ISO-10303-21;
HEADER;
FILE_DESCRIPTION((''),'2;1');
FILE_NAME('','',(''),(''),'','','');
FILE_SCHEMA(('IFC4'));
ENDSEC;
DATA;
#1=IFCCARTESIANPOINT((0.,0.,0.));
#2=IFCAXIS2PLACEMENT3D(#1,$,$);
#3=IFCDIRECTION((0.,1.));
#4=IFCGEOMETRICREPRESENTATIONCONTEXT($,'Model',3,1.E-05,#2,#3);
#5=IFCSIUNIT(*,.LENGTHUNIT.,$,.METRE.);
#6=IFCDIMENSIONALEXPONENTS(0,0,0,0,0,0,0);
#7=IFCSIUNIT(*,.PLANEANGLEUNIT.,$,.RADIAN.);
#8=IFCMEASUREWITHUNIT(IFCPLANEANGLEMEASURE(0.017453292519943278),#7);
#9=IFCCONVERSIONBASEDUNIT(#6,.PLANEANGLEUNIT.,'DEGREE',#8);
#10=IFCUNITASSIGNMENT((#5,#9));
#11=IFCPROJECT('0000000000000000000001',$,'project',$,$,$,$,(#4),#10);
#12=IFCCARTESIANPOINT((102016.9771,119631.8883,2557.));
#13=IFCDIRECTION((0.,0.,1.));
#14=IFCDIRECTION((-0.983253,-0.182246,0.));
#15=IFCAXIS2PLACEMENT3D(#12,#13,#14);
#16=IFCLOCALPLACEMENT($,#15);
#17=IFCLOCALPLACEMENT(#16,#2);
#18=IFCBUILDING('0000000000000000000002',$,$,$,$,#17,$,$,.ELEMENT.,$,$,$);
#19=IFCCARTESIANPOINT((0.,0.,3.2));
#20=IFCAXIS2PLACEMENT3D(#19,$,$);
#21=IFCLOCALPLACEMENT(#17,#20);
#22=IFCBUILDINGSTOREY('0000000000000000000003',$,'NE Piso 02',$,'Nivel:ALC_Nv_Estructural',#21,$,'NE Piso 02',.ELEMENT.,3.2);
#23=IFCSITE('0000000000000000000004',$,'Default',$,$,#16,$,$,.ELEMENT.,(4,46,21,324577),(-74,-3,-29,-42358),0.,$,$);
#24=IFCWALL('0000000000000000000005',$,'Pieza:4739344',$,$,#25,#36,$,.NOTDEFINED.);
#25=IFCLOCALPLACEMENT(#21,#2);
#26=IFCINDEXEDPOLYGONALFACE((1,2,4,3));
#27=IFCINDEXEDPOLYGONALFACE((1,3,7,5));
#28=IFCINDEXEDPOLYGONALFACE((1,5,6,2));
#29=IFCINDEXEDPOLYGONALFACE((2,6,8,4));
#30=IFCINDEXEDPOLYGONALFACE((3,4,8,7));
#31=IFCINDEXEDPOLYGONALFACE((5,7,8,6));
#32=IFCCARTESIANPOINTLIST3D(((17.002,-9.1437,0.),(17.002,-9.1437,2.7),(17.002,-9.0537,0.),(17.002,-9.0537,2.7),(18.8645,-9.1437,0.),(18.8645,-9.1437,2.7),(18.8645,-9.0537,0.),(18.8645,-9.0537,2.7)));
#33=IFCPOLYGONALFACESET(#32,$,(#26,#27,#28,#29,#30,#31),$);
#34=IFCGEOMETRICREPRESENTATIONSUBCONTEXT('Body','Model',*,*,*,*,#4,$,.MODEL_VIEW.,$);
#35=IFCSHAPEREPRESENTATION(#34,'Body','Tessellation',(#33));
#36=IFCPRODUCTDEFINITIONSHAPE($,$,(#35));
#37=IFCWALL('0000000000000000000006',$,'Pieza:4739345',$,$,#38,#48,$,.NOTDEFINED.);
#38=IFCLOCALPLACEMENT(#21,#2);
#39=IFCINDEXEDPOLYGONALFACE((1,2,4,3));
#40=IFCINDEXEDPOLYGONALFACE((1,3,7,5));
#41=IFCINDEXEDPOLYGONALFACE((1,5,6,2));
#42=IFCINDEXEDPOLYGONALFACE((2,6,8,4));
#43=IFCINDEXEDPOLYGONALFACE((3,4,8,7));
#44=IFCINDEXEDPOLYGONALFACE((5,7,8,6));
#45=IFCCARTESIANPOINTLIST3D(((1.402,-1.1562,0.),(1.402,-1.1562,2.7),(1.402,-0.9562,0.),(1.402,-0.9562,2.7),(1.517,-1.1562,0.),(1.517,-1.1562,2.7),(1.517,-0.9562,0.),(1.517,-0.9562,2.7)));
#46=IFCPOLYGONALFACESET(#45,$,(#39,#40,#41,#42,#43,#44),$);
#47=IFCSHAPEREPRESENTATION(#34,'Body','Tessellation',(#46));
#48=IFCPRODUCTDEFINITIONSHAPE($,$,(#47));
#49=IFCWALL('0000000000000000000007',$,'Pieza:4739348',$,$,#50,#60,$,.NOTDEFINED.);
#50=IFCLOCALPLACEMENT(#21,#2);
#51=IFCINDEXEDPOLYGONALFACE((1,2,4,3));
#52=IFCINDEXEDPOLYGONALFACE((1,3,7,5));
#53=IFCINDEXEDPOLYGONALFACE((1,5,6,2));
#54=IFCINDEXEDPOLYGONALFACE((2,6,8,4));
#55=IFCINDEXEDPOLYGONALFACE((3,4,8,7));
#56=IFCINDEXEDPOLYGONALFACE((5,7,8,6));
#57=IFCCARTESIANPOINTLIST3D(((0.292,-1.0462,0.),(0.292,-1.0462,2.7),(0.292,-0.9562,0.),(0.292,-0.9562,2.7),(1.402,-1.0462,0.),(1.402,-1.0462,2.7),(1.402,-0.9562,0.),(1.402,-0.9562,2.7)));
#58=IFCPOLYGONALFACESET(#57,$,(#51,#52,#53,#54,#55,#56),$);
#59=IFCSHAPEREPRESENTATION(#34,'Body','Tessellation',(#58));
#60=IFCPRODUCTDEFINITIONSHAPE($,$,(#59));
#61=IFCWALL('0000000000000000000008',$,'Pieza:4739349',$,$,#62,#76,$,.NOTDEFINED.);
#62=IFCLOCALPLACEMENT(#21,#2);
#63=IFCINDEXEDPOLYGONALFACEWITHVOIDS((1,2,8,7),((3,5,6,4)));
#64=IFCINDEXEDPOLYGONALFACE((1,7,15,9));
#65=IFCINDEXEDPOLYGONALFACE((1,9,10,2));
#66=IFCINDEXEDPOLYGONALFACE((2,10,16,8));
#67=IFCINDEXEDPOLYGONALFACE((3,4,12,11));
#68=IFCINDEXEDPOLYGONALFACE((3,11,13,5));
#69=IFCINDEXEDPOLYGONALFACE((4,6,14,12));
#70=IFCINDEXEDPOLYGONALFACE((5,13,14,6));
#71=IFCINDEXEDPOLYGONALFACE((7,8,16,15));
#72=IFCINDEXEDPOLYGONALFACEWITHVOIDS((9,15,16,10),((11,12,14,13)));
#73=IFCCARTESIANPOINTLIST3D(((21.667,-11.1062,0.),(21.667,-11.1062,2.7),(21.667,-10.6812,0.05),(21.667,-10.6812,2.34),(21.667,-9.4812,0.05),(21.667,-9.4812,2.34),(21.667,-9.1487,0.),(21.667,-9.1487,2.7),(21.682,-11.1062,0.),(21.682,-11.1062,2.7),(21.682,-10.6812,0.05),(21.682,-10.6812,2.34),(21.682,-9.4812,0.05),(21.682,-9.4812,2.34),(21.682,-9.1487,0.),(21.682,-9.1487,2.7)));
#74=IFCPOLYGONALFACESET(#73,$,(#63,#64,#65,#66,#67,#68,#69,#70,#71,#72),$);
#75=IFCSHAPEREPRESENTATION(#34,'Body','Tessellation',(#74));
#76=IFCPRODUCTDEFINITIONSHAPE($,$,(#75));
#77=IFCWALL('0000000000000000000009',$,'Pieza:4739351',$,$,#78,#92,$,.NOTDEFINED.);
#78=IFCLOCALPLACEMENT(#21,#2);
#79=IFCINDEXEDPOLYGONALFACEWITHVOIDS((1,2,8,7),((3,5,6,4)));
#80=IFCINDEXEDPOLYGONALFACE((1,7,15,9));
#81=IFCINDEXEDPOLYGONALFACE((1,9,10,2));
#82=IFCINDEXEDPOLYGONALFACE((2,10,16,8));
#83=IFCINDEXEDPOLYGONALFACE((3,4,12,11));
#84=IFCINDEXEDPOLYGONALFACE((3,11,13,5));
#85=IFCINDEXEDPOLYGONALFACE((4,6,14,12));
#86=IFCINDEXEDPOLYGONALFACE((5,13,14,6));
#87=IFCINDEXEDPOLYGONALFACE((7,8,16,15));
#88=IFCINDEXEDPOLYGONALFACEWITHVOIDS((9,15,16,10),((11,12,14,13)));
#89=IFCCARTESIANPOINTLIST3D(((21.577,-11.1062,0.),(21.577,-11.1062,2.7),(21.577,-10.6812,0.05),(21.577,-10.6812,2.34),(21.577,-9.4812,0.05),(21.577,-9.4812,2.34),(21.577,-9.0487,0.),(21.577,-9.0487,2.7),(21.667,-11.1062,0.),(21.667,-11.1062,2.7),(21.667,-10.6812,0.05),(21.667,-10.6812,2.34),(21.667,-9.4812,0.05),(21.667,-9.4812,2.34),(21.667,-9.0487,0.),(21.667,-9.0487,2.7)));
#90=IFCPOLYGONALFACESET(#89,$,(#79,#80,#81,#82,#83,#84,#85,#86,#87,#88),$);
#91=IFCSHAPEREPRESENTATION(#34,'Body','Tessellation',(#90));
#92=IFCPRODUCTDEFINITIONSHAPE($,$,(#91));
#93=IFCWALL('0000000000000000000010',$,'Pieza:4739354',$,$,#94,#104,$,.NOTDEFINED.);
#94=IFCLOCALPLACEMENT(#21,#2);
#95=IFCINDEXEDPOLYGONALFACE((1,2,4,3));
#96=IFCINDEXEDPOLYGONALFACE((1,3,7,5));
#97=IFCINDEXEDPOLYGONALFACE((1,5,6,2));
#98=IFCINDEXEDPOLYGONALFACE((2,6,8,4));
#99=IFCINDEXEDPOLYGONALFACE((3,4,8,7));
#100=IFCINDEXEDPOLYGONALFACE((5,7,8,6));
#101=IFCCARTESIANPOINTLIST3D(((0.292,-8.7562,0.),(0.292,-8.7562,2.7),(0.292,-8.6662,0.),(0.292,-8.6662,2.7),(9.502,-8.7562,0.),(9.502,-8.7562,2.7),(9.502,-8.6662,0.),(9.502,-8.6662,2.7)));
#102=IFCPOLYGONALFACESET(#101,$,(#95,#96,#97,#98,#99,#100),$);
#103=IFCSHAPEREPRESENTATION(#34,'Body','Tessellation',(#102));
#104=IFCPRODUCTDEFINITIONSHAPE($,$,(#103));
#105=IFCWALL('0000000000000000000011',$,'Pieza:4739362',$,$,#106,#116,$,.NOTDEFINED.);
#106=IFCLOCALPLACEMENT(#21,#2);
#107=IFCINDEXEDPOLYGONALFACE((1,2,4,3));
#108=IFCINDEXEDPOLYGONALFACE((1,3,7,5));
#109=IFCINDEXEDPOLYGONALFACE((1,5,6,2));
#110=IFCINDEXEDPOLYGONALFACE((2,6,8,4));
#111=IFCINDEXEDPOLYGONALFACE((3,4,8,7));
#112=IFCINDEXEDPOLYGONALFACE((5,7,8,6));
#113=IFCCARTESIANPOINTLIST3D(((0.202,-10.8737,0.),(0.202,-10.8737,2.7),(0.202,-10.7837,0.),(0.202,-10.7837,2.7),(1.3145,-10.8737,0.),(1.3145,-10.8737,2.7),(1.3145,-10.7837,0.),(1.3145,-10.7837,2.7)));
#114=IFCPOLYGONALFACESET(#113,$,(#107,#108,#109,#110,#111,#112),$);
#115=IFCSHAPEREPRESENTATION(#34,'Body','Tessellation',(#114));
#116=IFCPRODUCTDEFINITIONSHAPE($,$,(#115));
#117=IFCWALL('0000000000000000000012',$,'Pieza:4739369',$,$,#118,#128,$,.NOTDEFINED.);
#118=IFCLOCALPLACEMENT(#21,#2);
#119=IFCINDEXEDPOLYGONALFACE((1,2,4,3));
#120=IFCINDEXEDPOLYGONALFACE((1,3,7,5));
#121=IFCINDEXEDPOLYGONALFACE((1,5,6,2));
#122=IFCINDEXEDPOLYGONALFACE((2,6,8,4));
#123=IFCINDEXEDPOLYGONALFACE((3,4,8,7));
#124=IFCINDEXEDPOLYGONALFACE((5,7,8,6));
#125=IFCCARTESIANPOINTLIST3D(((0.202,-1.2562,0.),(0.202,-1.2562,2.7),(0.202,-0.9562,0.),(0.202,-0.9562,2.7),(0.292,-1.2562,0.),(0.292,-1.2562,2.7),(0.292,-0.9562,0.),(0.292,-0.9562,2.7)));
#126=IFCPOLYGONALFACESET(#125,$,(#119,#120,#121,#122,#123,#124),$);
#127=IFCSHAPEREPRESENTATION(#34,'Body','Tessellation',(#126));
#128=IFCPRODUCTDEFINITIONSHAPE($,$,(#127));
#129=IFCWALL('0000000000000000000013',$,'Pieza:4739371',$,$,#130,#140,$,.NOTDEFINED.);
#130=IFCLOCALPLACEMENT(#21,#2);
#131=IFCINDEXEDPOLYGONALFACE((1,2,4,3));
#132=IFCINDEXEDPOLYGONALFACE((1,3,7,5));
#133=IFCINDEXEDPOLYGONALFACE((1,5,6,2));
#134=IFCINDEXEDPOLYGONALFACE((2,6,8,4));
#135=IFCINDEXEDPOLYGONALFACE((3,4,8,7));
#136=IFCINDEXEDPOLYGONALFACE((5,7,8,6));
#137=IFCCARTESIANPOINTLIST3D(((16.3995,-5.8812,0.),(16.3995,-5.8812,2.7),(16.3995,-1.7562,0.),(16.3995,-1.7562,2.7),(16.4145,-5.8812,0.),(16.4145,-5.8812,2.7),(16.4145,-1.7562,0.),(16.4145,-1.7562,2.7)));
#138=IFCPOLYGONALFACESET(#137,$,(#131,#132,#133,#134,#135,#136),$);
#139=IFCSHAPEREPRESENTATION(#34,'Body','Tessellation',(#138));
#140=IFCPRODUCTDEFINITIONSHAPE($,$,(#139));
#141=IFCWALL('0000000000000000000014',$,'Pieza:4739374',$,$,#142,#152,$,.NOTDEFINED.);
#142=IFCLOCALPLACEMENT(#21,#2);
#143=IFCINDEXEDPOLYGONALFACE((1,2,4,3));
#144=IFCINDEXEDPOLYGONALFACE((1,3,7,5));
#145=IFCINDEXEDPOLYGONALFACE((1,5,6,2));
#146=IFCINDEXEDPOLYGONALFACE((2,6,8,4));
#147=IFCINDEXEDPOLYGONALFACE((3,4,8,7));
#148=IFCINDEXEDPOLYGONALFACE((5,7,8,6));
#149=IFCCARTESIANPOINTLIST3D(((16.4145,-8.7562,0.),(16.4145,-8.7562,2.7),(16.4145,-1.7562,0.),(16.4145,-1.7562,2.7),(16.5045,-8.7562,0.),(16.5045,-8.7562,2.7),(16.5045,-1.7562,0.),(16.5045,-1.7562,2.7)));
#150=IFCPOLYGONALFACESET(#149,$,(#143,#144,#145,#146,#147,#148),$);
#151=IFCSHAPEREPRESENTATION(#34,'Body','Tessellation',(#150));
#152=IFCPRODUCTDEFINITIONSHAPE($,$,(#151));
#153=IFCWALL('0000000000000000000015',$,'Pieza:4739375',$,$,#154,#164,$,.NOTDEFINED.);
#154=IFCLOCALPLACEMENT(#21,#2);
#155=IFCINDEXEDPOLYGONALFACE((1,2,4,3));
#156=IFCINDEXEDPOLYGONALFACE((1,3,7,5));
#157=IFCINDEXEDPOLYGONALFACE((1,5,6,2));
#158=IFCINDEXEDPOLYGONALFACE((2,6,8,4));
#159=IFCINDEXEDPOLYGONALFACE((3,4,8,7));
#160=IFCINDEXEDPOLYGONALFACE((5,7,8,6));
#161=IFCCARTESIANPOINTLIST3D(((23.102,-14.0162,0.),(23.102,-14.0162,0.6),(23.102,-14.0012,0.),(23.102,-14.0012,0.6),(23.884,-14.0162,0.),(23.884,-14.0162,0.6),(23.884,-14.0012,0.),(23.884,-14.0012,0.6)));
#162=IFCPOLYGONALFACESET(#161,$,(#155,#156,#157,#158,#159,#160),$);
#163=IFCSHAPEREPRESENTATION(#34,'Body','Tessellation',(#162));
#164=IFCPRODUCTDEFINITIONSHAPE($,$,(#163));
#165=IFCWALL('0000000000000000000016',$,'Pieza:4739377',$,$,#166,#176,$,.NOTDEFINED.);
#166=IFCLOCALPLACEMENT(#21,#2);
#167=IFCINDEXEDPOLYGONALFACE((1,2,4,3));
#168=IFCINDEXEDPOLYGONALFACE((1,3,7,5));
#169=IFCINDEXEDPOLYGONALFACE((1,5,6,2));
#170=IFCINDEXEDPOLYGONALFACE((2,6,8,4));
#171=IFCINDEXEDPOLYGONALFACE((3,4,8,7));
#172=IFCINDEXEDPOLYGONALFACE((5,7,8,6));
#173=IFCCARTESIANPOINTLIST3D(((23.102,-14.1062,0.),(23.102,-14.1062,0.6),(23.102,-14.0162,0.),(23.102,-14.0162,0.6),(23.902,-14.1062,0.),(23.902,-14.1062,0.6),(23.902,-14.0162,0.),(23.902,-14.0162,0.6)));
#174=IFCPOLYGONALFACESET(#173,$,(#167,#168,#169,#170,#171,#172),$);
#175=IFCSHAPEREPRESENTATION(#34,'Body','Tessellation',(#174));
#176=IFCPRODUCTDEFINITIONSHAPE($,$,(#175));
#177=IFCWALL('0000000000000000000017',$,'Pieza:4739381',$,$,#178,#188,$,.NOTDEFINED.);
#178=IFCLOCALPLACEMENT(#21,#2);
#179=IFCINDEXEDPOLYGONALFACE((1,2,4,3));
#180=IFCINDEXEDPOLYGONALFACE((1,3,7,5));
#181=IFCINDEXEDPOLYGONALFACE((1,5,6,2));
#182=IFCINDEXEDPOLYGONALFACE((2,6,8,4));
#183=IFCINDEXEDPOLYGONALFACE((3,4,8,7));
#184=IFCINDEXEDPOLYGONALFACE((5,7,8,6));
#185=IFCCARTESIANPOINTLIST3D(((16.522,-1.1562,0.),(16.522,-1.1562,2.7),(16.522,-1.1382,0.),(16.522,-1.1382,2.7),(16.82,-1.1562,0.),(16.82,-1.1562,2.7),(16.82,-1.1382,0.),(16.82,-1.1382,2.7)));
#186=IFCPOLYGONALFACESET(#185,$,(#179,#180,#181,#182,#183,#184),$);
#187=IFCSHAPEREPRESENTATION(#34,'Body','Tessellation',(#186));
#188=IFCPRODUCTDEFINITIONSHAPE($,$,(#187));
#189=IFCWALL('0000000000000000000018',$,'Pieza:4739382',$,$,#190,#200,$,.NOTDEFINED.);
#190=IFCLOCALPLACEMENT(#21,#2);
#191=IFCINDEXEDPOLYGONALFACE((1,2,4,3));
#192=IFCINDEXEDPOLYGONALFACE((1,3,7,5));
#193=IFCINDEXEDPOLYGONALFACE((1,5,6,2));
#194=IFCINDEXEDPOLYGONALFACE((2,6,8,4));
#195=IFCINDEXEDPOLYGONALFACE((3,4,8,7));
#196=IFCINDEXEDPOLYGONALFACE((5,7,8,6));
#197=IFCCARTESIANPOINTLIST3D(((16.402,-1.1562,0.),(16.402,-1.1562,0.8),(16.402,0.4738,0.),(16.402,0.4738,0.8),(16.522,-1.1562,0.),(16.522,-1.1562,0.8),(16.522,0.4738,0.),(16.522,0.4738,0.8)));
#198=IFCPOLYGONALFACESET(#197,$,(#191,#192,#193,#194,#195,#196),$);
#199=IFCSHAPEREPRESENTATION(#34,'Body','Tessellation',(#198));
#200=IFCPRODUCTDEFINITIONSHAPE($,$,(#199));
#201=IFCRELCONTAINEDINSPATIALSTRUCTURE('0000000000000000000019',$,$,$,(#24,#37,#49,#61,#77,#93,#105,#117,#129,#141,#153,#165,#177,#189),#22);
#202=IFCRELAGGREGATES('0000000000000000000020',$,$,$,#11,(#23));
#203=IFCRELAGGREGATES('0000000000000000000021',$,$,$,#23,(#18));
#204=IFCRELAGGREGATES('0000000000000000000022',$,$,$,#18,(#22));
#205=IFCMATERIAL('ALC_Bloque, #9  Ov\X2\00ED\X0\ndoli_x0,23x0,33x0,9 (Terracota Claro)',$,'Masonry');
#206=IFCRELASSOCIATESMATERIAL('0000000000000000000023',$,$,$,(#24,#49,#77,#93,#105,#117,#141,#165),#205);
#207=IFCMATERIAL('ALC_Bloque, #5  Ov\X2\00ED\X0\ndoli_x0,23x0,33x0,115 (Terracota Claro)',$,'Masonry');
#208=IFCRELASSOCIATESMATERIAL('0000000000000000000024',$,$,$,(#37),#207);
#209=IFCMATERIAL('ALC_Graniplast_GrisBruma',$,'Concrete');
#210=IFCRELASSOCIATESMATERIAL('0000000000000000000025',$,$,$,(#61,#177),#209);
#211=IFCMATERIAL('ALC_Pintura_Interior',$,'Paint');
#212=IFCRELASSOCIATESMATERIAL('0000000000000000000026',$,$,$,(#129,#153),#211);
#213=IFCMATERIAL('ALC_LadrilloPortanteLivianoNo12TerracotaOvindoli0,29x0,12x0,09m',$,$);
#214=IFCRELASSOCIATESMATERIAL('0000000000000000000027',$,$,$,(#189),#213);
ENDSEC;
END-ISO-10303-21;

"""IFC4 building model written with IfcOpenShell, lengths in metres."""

from ifc_helpers import new_model, entity, si_unit, converted_unit, direction, frame, frame_2d, origin, origin_2d_with_axis, place, context, subcontext, project, spatial, rectangle, extrude, boolean, material, element, save


model = new_model("IFC4")

# Units and contexts
model_context = context("Model", 3, precision=1e-05, world=origin(), true_north=direction((0.0, 1.0)))
body_context = subcontext(model_context, "Body", "Model", "MODEL_VIEW")
ifc_project = project(units=[si_unit("LENGTHUNIT", "METRE"), converted_unit("PLANEANGLEUNIT", "DEGREE", entity("IfcPlaneAngleMeasure", 0.017453292519943278), si_unit("PLANEANGLEUNIT", "RADIAN"), dimensions=[0, 0, 0, 0, 0, 0, 0])], contexts=[model_context])

# Site, building, storey
site_placement = place(None, frame((102016.9771, 119631.8883, 2557.0), z_axis=(0.0, 0.0, 1.0), x_axis=(-0.983253, -0.182246, 0.0)))
site = spatial("IfcSite", under=ifc_project, at=site_placement, Name="Default", CompositionType="ELEMENT", RefLatitude=(4, 46, 21, 324577), RefLongitude=(-74, -3, -29, -42358), RefElevation=0.0)
building_placement = place(site_placement, origin())
building = spatial("IfcBuilding", under=site, at=building_placement, CompositionType="ELEMENT")
storey_placement = place(building_placement, frame((0.0, 0.0, 3.2)))
storey = spatial("IfcBuildingStorey", under=building, at=storey_placement, Name="NE Piso 02", ObjectType="Nivel:ALC_Nv_Estructural", LongName="NE Piso 02", CompositionType="ELEMENT", Elevation=3.2)

# Walls
ifc_material_1 = material(Name="ALC_Bloque, #9  Ovíndoli_x0,23x0,33x0,9 (Terracota Claro)", Category="Masonry")
wall_1_placement = place(storey_placement, origin())
element("IfcWall", 1, at=wall_1_placement, inside=storey, material=ifc_material_1, Name="Pieza:4739344", PredefinedType="NOTDEFINED", context=body_context, shape_type="SweptSolid", body=[
    extrude(rectangle(XDim=0.09, YDim=1.8625, at=frame_2d((0.0, 0.0), x_axis=(1.0, 0.0))), frame((17.9333, -9.0987, 0.0), z_axis=(0.0, 0.0, 1.0), x_axis=(0.0, -1.0, 0.0)), (0.0, 0.0, 1.0), 2.7),
])
ifc_material_2 = material(Name="ALC_Bloque, #5  Ovíndoli_x0,23x0,33x0,115 (Terracota Claro)", Category="Masonry")
wall_2_placement = place(storey_placement, origin())
element("IfcWall", 2, at=wall_2_placement, inside=storey, material=ifc_material_2, Name="Pieza:4739345", PredefinedType="NOTDEFINED", context=body_context, shape_type="SweptSolid", body=[
    extrude(rectangle(XDim=0.2, YDim=0.115, at=frame_2d((0.0, 0.0), x_axis=(1.0, 0.0))), frame((1.4595, -1.0562, 0.0), z_axis=(0.0, 0.0, 1.0), x_axis=(0.0, -1.0, 0.0)), (0.0, 0.0, 1.0), 2.7),
])
wall_3_placement = place(storey_placement, origin())
element("IfcWall", 3, at=wall_3_placement, inside=storey, material=ifc_material_1, Name="Pieza:4739348", PredefinedType="NOTDEFINED", context=body_context, shape_type="SweptSolid", body=[
    extrude(rectangle(XDim=0.09, YDim=1.11, at=frame_2d((0.0, 0.0), x_axis=(1.0, 0.0))), frame((0.847, -1.0012, 0.0), z_axis=(0.0, 0.0, 1.0), x_axis=(0.0, -1.0, 0.0)), (0.0, 0.0, 1.0), 2.7),
])

# Wall, opening
ifc_material_3 = material(Name="ALC_Graniplast_GrisBruma", Category="Concrete")
wall_4_placement = place(storey_placement, origin())
wall_4 = element("IfcWall", 4, at=wall_4_placement, inside=storey, material=ifc_material_3, Name="Pieza:4739349", PredefinedType="NOTDEFINED", context=body_context, shape_type="SweptSolid", body=[
    extrude(rectangle(XDim=0.015, YDim=1.9575, at=frame_2d((0.0, 0.0), x_axis=(1.0, 0.0))), frame((21.6745, -10.1274, 0.0), z_axis=(0.0, 0.0, 1.0), x_axis=(-1.0, 0.0, 0.0)), (0.0, 0.0, 1.0), 2.7),
])
opening_placement = place(storey_placement, origin())
element("IfcOpeningElement", 5, at=opening_placement, cuts=wall_4, PredefinedType="OPENING", context=body_context, shape_type="SweptSolid", body=[
    extrude(rectangle(XDim=2.29, YDim=1.2, at=frame_2d((0.0, 0.0), x_axis=(0.0, 1.0))), frame((21.667, -10.0812, 1.195), z_axis=(1.0, 0.0, 0.0), x_axis=(0.0, 1.0, 0.0)), (0.0, 0.0, 1.0), 0.015),
])

# Walls
wall_5_placement = place(storey_placement, origin())
element("IfcWall", 6, at=wall_5_placement, inside=storey, material=ifc_material_1, Name="Pieza:4739351", PredefinedType="NOTDEFINED", context=body_context, shape_type="SweptSolid", body=[
    boolean("DIFFERENCE", extrude(rectangle(XDim=0.09, YDim=2.0575, at=frame_2d((0.0, 0.0), x_axis=(1.0, 0.0))), frame((21.622, -10.0774, 0.0)), (0.0, 0.0, 1.0), 2.7), extrude(rectangle(XDim=2.29, YDim=1.2, at=frame_2d((0.0, 0.0), x_axis=(0.0, 1.0))), frame((21.667, -10.0812, 1.195), z_axis=(1.0, 0.0, 0.0), x_axis=(0.0, -1.0, 0.0)), (0.0, 0.0, -1.0), 0.09)),
])
wall_6_placement = place(storey_placement, origin())
element("IfcWall", 7, at=wall_6_placement, inside=storey, material=ifc_material_1, Name="Pieza:4739354", PredefinedType="NOTDEFINED", context=body_context, shape_type="SweptSolid", body=[
    extrude(rectangle(XDim=0.09, YDim=9.21, at=frame_2d((0.0, 0.0), x_axis=(1.0, 0.0))), frame((4.897, -8.7112, 0.0), z_axis=(0.0, 0.0, 1.0), x_axis=(0.0, -1.0, 0.0)), (0.0, 0.0, 1.0), 2.7),
])
wall_7_placement = place(storey_placement, origin())
element("IfcWall", 8, at=wall_7_placement, inside=storey, material=ifc_material_1, Name="Pieza:4739362", PredefinedType="NOTDEFINED", context=body_context, shape_type="SweptSolid", body=[
    extrude(rectangle(XDim=0.09, YDim=1.1125, at=frame_2d((0.0, 0.0), x_axis=(1.0, 0.0))), frame((0.7583, -10.8287, 0.0), z_axis=(0.0, 0.0, 1.0), x_axis=(0.0, -1.0, 0.0)), (0.0, 0.0, 1.0), 2.7),
])
wall_8_placement = place(storey_placement, origin())
element("IfcWall", 9, at=wall_8_placement, inside=storey, material=ifc_material_1, Name="Pieza:4739369", PredefinedType="NOTDEFINED", context=body_context, shape_type="SweptSolid", body=[
    extrude(rectangle(XDim=0.3, YDim=0.09, at=frame_2d((0.0, 0.0), x_axis=(1.0, 0.0))), frame((0.247, -1.1062, 0.0), z_axis=(0.0, 0.0, 1.0), x_axis=(0.0, -1.0, 0.0)), (0.0, 0.0, 1.0), 2.7),
])
ifc_material_4 = material(Name="ALC_Pintura_Interior", Category="Paint")
wall_9_placement = place(storey_placement, origin())
element("IfcWall", 10, at=wall_9_placement, inside=storey, material=ifc_material_4, Name="Pieza:4739371", PredefinedType="NOTDEFINED", context=body_context, shape_type="SweptSolid", body=[
    extrude(rectangle(XDim=4.125, YDim=0.015, at=frame_2d((0.0, 0.0), x_axis=(1.0, 0.0))), frame((16.407, -3.8187, 0.0), z_axis=(0.0, 0.0, 1.0), x_axis=(0.0, -1.0, 0.0)), (0.0, 0.0, 1.0), 2.7),
])
wall_10_placement = place(storey_placement, origin())
element("IfcWall", 11, at=wall_10_placement, inside=storey, material=ifc_material_1, Name="Pieza:4739374", PredefinedType="NOTDEFINED", context=body_context, shape_type="SweptSolid", body=[
    extrude(rectangle(XDim=7.0, YDim=0.09, at=frame_2d((0.0, 0.0), x_axis=(1.0, 0.0))), frame((16.4595, -5.2562, 0.0), z_axis=(0.0, 0.0, 1.0), x_axis=(0.0, -1.0, 0.0)), (0.0, 0.0, 1.0), 2.7),
])
wall_11_placement = place(storey_placement, origin())
element("IfcWall", 12, at=wall_11_placement, inside=storey, material=ifc_material_4, Name="Pieza:4739375", PredefinedType="NOTDEFINED", context=body_context, shape_type="SweptSolid", body=[
    extrude(rectangle(XDim=0.015, YDim=0.782, at=origin_2d_with_axis()), frame((23.493, -14.0087, 0.0), z_axis=(0.0, 0.0, 1.0), x_axis=(0.0, -1.0, 0.0)), (0.0, 0.0, 1.0), 0.6),
])
wall_12_placement = place(storey_placement, origin())
element("IfcWall", 13, at=wall_12_placement, inside=storey, material=ifc_material_1, Name="Pieza:4739377", PredefinedType="NOTDEFINED", context=body_context, shape_type="SweptSolid", body=[
    extrude(rectangle(XDim=0.09, YDim=0.8, at=frame_2d((0.0, 0.0), x_axis=(1.0, 0.0))), frame((23.502, -14.0612, 0.0), z_axis=(0.0, 0.0, 1.0), x_axis=(0.0, -1.0, 0.0)), (0.0, 0.0, 1.0), 0.6),
])
wall_13_placement = place(storey_placement, origin())
element("IfcWall", 14, at=wall_13_placement, inside=storey, material=ifc_material_3, Name="Pieza:4739381", PredefinedType="NOTDEFINED", context=body_context, shape_type="SweptSolid", body=[
    extrude(rectangle(XDim=0.018, YDim=0.298, at=frame_2d((0.0, 0.0), x_axis=(1.0, 0.0))), frame((16.671, -1.1472, 0.0), z_axis=(0.0, 0.0, 1.0), x_axis=(0.0, -1.0, 0.0)), (0.0, 0.0, 1.0), 2.7),
])
ifc_material_5 = material(Name="ALC_LadrilloPortanteLivianoNo12TerracotaOvindoli0,29x0,12x0,09m")
wall_14_placement = place(storey_placement, origin())
element("IfcWall", 15, at=wall_14_placement, inside=storey, material=ifc_material_5, Name="Pieza:4739382", PredefinedType="NOTDEFINED", context=body_context, shape_type="SweptSolid", body=[
    extrude(rectangle(XDim=1.63, YDim=0.12, at=frame_2d((0.0, 0.0), x_axis=(1.0, 0.0))), frame((16.462, -0.3412, 0.0), z_axis=(0.0, 0.0, 1.0), x_axis=(0.0, -1.0, 0.0)), (0.0, 0.0, 1.0), 0.8),
])

save(model, "model.ifc")
